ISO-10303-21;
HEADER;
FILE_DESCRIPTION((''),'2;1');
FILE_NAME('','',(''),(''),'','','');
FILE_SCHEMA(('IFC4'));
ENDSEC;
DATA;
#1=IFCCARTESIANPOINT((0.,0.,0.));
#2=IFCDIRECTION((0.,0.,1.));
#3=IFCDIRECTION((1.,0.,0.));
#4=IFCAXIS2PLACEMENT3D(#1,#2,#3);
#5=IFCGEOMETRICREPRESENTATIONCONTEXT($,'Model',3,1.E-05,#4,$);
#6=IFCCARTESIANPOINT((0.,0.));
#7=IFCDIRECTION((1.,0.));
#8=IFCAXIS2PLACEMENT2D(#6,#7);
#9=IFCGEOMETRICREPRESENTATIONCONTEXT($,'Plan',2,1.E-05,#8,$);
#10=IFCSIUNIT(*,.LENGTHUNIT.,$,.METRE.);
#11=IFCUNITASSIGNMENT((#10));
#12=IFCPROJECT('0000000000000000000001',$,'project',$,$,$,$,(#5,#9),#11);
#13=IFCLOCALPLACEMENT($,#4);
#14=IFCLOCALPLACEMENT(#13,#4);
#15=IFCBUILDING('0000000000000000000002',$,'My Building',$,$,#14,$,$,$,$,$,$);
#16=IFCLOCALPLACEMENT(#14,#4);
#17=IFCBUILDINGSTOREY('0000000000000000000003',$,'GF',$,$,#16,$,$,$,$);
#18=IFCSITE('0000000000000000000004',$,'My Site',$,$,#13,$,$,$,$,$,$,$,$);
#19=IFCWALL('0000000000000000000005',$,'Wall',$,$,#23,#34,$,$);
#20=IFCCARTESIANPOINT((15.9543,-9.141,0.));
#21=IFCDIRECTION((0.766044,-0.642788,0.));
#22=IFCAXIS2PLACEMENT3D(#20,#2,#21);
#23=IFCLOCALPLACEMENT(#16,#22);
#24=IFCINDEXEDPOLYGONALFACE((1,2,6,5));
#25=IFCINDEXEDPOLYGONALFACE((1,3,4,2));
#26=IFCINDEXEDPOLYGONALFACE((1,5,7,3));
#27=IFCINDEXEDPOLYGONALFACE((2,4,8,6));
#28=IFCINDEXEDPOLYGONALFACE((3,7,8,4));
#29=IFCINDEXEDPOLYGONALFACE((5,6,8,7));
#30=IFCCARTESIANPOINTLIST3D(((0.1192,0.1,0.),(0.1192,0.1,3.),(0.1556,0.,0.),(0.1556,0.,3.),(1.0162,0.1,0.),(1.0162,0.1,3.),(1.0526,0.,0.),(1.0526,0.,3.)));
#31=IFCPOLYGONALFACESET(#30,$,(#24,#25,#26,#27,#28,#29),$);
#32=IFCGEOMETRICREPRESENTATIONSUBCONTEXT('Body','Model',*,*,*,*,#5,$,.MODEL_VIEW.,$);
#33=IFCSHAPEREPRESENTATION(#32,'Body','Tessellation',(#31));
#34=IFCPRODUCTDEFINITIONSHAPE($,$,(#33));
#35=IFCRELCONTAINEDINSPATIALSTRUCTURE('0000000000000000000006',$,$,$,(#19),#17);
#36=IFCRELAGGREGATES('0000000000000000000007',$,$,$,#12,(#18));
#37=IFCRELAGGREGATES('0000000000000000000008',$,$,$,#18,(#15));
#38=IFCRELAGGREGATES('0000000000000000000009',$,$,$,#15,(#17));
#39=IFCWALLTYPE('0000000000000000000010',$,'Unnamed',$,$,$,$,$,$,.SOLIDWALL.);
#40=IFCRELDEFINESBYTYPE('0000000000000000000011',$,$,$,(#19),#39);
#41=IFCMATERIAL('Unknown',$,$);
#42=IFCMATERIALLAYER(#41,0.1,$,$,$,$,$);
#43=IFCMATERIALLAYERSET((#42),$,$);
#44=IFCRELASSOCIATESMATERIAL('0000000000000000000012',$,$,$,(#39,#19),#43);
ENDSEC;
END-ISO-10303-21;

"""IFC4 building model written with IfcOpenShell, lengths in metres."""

from ifc_helpers import new_model, si_unit, frame, origin_with_axes, origin_2d_with_axis, place, context, subcontext, project, spatial, line, indexed_curve, outline, extrude, material, layer, layer_set, layer_usage, type_object, element, save


model = new_model("IFC4")

# Units and contexts
model_context = context("Model", 3, precision=1e-05, world=origin_with_axes())
plan_context = context("Plan", 2, precision=1e-05, world=origin_2d_with_axis())
body_context_1 = subcontext(model_context, "Body", "Model", "MODEL_VIEW")
ifc_project = project(units=[si_unit("LENGTHUNIT", "METRE")], contexts=[model_context, plan_context])

# Site, building, storey
site_placement = place(None, origin_with_axes())
site = spatial("IfcSite", under=ifc_project, at=site_placement, Name="My Site")
building_placement = place(site_placement, origin_with_axes())
building = spatial("IfcBuilding", under=site, at=building_placement, Name="My Building")
storey_placement = place(building_placement, origin_with_axes())
storey = spatial("IfcBuildingStorey", under=building, at=storey_placement, Name="GF")

# Shared definitions
ifc_material = material(Name="Unknown")

# Shared definitions
ifc_layer_1 = layer(ifc_material, 0.1)
ifc_layer_set_1 = layer_set([ifc_layer_1])
wall_type = type_object("IfcWallType", Name="Unnamed", PredefinedType="SOLIDWALL", material=ifc_layer_set_1)

# Wall
ifc_layer_usage_1 = layer_usage(ifc_layer_set_1, "AXIS2", "POSITIVE", 0.0)
wall_1_placement = place(storey_placement, frame((15.9543, -9.141, 0.0), z_axis=(0.0, 0.0, 1.0), x_axis=(0.766044, -0.642788, 0.0)))
element("IfcWall", 1, at=wall_1_placement, inside=storey, type_object=wall_type, material=ifc_layer_usage_1, Name="Wall", context=body_context_1, shape_type="SweptSolid", body=[
    extrude(outline(indexed_curve([(0.1556, 0.0), (0.1192, 0.1), (1.0162, 0.1), (1.0526, 0.0)], segments=[line(1, 2, 3, 4, 1)])), origin_with_axes(), (0.0, 0.0, 1.0), 3.0),
])

save(model, "model.ifc")
